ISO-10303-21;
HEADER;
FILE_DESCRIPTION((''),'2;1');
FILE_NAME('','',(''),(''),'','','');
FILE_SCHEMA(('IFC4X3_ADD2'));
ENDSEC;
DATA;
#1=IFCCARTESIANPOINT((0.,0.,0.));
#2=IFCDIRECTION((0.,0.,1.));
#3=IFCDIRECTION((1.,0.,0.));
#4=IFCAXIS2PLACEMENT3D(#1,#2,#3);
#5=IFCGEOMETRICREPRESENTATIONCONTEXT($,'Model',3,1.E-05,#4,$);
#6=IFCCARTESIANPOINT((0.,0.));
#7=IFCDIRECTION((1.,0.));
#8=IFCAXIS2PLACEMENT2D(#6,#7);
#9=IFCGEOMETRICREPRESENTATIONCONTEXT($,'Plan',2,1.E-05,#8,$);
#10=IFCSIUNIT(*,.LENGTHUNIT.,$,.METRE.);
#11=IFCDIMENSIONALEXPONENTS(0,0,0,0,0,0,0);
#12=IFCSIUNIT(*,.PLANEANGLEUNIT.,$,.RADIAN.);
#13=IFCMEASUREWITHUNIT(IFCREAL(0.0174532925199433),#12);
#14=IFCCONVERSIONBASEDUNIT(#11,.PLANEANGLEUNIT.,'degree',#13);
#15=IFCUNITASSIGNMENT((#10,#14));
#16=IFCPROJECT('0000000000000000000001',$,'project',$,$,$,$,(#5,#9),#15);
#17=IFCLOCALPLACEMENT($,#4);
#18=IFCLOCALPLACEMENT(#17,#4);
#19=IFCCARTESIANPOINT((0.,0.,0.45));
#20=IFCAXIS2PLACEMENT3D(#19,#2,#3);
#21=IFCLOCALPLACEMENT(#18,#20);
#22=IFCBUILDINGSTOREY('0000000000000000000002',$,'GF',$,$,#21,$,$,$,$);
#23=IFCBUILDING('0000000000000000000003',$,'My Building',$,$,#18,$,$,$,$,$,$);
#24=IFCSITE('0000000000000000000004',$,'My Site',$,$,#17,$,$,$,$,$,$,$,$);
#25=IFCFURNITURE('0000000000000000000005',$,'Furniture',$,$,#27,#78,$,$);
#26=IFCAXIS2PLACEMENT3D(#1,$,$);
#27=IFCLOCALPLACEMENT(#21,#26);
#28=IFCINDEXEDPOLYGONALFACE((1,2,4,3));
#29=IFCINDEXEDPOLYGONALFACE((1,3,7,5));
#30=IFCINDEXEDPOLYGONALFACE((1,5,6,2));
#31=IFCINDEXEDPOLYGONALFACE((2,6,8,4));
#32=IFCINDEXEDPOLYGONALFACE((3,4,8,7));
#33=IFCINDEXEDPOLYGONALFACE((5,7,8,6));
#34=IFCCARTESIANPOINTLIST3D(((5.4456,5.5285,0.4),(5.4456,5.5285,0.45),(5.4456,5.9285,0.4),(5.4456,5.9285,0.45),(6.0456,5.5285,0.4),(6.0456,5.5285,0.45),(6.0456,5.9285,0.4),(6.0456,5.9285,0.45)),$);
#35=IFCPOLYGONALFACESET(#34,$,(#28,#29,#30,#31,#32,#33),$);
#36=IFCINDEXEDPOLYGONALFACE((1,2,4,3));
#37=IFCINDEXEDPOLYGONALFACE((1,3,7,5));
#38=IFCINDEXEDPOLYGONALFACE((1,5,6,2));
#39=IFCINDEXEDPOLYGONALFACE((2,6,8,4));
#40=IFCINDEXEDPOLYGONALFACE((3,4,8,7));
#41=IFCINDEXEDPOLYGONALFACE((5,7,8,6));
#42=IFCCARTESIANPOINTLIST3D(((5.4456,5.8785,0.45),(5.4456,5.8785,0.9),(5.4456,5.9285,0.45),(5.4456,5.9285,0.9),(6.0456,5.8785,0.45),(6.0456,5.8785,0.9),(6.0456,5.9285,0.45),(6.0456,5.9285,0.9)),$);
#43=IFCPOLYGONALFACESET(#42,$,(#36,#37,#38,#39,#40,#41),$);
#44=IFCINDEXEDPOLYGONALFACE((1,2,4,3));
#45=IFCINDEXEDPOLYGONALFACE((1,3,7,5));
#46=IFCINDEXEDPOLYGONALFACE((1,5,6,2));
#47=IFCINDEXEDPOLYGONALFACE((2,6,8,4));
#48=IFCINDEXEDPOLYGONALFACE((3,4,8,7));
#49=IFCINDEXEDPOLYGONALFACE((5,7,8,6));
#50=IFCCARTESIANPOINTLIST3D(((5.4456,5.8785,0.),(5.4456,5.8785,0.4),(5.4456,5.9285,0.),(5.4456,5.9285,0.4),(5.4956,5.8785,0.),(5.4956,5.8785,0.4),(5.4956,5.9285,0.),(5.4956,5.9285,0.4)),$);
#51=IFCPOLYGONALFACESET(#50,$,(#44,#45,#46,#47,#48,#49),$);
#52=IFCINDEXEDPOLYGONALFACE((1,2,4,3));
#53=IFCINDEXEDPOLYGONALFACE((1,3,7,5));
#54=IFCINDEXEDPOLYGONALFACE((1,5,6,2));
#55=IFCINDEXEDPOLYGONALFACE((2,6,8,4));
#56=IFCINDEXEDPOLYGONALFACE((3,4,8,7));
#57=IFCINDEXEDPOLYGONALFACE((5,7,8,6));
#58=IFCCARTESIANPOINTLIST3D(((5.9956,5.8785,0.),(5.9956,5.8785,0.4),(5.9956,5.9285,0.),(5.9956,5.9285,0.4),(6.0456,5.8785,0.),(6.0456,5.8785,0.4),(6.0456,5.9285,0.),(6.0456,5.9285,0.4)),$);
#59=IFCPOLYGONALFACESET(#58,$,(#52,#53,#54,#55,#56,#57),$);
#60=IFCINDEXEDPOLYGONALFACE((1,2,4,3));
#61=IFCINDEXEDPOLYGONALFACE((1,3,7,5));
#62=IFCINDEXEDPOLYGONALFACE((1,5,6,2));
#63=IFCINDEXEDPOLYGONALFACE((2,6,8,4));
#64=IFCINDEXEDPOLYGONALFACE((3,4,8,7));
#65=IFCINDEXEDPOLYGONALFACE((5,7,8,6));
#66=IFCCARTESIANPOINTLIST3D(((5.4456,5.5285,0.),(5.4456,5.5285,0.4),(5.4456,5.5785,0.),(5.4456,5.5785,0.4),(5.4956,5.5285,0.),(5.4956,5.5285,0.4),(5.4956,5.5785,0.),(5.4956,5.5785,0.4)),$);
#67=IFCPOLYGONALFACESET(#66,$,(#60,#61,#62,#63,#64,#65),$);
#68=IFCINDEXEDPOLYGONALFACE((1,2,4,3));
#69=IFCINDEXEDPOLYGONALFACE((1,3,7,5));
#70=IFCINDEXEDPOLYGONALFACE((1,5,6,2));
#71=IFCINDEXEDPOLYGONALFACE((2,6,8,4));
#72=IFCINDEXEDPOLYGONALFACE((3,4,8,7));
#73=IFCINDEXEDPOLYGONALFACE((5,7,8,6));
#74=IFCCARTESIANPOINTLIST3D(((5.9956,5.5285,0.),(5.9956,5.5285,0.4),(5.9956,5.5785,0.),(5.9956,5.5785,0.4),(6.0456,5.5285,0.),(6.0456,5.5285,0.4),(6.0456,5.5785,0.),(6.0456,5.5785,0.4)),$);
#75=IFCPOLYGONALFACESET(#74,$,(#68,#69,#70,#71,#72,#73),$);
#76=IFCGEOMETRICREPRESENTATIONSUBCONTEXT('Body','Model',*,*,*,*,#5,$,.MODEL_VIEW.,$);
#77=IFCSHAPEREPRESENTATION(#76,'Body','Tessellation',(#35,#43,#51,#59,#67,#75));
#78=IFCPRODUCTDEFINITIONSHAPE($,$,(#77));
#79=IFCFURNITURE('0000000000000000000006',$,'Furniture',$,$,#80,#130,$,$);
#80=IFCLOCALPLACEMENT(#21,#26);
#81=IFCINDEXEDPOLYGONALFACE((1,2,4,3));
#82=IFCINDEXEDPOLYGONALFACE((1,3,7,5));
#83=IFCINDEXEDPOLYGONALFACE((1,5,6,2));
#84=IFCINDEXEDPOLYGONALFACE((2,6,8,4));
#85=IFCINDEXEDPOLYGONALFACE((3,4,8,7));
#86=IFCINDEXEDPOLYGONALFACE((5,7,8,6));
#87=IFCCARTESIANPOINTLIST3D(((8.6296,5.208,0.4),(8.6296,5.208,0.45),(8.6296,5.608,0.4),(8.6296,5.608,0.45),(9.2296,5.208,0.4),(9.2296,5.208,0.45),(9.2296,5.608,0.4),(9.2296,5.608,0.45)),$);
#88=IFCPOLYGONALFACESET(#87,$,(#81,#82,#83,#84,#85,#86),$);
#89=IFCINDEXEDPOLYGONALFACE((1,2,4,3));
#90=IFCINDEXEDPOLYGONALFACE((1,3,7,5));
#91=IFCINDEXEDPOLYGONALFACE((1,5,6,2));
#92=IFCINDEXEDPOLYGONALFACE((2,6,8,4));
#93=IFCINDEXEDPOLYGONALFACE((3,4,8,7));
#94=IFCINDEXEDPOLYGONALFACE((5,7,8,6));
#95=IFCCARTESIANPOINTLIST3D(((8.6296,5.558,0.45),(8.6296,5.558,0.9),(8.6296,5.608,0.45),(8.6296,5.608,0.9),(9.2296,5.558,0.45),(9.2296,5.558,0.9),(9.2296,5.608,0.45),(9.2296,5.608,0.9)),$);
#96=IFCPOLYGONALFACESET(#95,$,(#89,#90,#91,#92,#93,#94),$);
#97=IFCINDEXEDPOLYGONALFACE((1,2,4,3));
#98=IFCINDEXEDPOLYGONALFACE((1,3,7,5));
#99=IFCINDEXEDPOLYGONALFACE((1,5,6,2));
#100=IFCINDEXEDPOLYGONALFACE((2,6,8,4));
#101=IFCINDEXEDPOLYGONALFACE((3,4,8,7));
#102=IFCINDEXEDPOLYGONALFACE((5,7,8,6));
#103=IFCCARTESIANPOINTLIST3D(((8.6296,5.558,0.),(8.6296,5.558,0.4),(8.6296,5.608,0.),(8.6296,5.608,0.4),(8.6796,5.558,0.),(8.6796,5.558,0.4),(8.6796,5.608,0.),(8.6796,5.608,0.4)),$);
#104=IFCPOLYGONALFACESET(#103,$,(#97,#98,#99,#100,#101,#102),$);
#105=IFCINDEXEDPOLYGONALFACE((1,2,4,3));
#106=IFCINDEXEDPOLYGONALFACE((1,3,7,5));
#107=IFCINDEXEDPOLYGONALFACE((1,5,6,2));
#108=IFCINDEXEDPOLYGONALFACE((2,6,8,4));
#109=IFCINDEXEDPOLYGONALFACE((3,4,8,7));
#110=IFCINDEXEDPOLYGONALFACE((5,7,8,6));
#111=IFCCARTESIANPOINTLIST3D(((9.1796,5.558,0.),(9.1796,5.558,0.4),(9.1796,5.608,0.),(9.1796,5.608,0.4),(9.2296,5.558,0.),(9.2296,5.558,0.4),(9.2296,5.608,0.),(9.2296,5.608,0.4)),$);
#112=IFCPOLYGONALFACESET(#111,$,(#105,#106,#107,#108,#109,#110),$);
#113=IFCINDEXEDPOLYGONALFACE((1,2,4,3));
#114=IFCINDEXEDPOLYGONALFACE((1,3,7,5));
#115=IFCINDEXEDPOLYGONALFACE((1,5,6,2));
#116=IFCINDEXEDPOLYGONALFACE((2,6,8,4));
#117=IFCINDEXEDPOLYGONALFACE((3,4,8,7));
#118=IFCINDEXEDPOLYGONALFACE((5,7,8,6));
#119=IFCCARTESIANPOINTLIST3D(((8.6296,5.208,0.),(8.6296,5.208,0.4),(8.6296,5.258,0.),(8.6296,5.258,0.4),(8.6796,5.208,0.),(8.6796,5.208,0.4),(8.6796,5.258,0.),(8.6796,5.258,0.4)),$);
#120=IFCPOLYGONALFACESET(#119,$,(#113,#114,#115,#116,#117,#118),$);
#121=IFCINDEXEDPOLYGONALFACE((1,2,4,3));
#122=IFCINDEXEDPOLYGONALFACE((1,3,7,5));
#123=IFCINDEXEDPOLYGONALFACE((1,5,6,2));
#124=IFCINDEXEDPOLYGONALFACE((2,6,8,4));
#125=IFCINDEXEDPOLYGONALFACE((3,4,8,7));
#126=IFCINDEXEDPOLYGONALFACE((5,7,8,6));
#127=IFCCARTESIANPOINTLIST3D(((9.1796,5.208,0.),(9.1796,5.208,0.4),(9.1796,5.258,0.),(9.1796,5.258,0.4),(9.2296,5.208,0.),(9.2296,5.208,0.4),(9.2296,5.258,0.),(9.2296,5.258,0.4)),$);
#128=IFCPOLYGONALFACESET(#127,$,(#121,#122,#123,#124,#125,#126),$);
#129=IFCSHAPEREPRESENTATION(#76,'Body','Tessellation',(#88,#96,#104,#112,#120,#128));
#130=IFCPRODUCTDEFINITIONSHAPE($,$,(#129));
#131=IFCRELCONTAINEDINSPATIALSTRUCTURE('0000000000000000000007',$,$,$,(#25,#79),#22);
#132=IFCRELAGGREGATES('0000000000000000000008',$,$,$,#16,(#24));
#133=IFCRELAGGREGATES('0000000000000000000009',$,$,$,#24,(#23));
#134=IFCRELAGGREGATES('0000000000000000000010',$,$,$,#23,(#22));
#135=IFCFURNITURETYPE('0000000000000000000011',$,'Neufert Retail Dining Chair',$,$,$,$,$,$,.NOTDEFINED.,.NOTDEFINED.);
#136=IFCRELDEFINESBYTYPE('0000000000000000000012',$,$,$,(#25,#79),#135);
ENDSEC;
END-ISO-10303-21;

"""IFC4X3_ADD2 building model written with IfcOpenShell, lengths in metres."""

from ifc_helpers import new_model, entity, si_unit, converted_unit, frame, origin_with_axes, origin_2d_with_axis, place, context, subcontext, project, spatial, line, indexed_curve, outline, extrude, shape, source, transform, mapped, type_object, type_shapes, element, save


model = new_model("IFC4X3_ADD2")

# Units and contexts
model_context = context("Model", 3, precision=1e-05, world=origin_with_axes())
plan_context = context("Plan", 2, precision=1e-05, world=origin_2d_with_axis())
body_context_1 = subcontext(model_context, "Body", "Model", "MODEL_VIEW")
body_context_2 = subcontext(plan_context, "Body", "Plan", "PLAN_VIEW")
ifc_project = project(units=[si_unit("LENGTHUNIT", "METRE"), converted_unit("PLANEANGLEUNIT", "degree", entity("IfcReal", 0.0174532925199433), si_unit("PLANEANGLEUNIT", "RADIAN"), dimensions=[0, 0, 0, 0, 0, 0, 0])], contexts=[model_context, plan_context])

# Site, building, storey
site_placement = place(None, origin_with_axes())
site = spatial("IfcSite", under=ifc_project, at=site_placement, Name="My Site")
building_placement = place(site_placement, origin_with_axes())
building = spatial("IfcBuilding", under=site, at=building_placement, Name="My Building")
storey_placement = place(building_placement, frame((0.0, 0.0, 0.45), z_axis=(0.0, 0.0, 1.0), x_axis=(1.0, 0.0, 0.0)))
storey = spatial("IfcBuildingStorey", under=building, at=storey_placement, Name="GF")

# Furniture
furniture_type_1 = type_object("IfcFurnitureType", Name="Neufert Retail Dining Chair", AssemblyPlace="NOTDEFINED", PredefinedType="NOTDEFINED")
shared_shape_1 = source(origin_with_axes(), body_context_1, "Body", "SweptSolid", [
    extrude(outline(indexed_curve([(-0.3, 0.0), (0.3, 0.0), (0.3, -0.4), (-0.3, -0.4)], segments=[line(1, 2, 3, 4, 1)])), frame((0.0, 0.0, 0.45), z_axis=(0.0, 0.0, 1.0), x_axis=(1.0, 0.0, 0.0)), (0.0, 0.0, -1.0), 0.05),
    extrude(outline(indexed_curve([(-0.3, 0.0), (0.3, 0.0), (0.3, -0.05), (-0.3, -0.05)], segments=[line(1, 2, 3, 4, 1)])), frame((0.0, 0.0, 0.9), z_axis=(0.0, 0.0, 1.0), x_axis=(1.0, 0.0, 0.0)), (0.0, 0.0, -1.0), 0.45),
    extrude(outline(indexed_curve([(-0.3, 0.0), (-0.25, 0.0), (-0.25, -0.05), (-0.3, -0.05)], segments=[line(1, 2, 3, 4, 1)])), origin_with_axes(), (0.0, 0.0, 1.0), 0.4),
    extrude(outline(indexed_curve([(0.3, 0.0), (0.25, 0.0), (0.25, -0.05), (0.3, -0.05)], segments=[line(1, 2, 3, 4, 1)])), origin_with_axes(), (0.0, 0.0, 1.0), 0.4),
    extrude(outline(indexed_curve([(-0.3, -0.4), (-0.25, -0.4), (-0.25, -0.35), (-0.3, -0.35)], segments=[line(1, 2, 3, 4, 1)])), origin_with_axes(), (0.0, 0.0, 1.0), 0.4),
    extrude(outline(indexed_curve([(0.3, -0.4), (0.25, -0.4), (0.25, -0.35), (0.3, -0.35)], segments=[line(1, 2, 3, 4, 1)])), origin_with_axes(), (0.0, 0.0, 1.0), 0.4),
])
shared_shape_2 = source(origin_with_axes(), body_context_2, "Body", "Curve2D", [
    entity("IfcIndexedPolyCurve", entity("IfcCartesianPointList2D", [[-0.3, -0.4], [0.3, -0.4]])),
    entity("IfcIndexedPolyCurve", entity("IfcCartesianPointList2D", [[-0.3, -0.4], [-0.3, -0.3], [-0.2121, -0.0879], [0.0, 0.0], [0.2121, -0.0879], [0.3, -0.3], [0.3, -0.4]]), [entity("IfcLineIndex", [1, 2]), entity("IfcArcIndex", [2, 3, 4]), entity("IfcArcIndex", [4, 5, 6]), entity("IfcLineIndex", [6, 7])]),
    entity("IfcIndexedPolyCurve", entity("IfcCartesianPointList2D", [[-0.26, -0.4], [-0.26, -0.3], [-0.1838, -0.1162], [0.0, -0.04], [0.1838, -0.1162], [0.26, -0.3], [0.26, -0.4]]), [entity("IfcLineIndex", [1, 2]), entity("IfcArcIndex", [2, 3, 4]), entity("IfcArcIndex", [4, 5, 6]), entity("IfcLineIndex", [6, 7])]),
])
type_shapes(furniture_type_1, [shared_shape_1, shared_shape_2])
for number, where, z_axis, x_axis, name in (
    (1, (5.7456, 5.9285, 0.0), (0.0, 0.0, 1.0), (1.0, -0.000001, 0.0), "Furniture"),
    (2, (8.9296, 5.608, 0.0), (0.0, 0.0, 1.0), (1.0, -0.000001, 0.0), "Furniture"),
):
    element("IfcFurniture", number, at=place(storey_placement, frame(where, z_axis=z_axis, x_axis=x_axis)), inside=storey, type_object=furniture_type_1, Name=name, shapes=[
        shape(body_context_1, "Body", "MappedRepresentation", [mapped(shared_shape_1, transform((0.0, 0.0, 0.0), x_axis=(1.0, 0.0, 0.0), y_axis=(0.0, 1.0, 0.0), z_axis=(0.0, 0.0, 1.0), scale=1.0))]),
        shape(body_context_2, "Body", "MappedRepresentation", [mapped(shared_shape_2, transform((0.0, 0.0, 0.0), x_axis=(1.0, 0.0, 0.0), y_axis=(0.0, 1.0, 0.0), z_axis=(0.0, 0.0, 1.0), scale=1.0))]),
    ])

save(model, "model.ifc")
